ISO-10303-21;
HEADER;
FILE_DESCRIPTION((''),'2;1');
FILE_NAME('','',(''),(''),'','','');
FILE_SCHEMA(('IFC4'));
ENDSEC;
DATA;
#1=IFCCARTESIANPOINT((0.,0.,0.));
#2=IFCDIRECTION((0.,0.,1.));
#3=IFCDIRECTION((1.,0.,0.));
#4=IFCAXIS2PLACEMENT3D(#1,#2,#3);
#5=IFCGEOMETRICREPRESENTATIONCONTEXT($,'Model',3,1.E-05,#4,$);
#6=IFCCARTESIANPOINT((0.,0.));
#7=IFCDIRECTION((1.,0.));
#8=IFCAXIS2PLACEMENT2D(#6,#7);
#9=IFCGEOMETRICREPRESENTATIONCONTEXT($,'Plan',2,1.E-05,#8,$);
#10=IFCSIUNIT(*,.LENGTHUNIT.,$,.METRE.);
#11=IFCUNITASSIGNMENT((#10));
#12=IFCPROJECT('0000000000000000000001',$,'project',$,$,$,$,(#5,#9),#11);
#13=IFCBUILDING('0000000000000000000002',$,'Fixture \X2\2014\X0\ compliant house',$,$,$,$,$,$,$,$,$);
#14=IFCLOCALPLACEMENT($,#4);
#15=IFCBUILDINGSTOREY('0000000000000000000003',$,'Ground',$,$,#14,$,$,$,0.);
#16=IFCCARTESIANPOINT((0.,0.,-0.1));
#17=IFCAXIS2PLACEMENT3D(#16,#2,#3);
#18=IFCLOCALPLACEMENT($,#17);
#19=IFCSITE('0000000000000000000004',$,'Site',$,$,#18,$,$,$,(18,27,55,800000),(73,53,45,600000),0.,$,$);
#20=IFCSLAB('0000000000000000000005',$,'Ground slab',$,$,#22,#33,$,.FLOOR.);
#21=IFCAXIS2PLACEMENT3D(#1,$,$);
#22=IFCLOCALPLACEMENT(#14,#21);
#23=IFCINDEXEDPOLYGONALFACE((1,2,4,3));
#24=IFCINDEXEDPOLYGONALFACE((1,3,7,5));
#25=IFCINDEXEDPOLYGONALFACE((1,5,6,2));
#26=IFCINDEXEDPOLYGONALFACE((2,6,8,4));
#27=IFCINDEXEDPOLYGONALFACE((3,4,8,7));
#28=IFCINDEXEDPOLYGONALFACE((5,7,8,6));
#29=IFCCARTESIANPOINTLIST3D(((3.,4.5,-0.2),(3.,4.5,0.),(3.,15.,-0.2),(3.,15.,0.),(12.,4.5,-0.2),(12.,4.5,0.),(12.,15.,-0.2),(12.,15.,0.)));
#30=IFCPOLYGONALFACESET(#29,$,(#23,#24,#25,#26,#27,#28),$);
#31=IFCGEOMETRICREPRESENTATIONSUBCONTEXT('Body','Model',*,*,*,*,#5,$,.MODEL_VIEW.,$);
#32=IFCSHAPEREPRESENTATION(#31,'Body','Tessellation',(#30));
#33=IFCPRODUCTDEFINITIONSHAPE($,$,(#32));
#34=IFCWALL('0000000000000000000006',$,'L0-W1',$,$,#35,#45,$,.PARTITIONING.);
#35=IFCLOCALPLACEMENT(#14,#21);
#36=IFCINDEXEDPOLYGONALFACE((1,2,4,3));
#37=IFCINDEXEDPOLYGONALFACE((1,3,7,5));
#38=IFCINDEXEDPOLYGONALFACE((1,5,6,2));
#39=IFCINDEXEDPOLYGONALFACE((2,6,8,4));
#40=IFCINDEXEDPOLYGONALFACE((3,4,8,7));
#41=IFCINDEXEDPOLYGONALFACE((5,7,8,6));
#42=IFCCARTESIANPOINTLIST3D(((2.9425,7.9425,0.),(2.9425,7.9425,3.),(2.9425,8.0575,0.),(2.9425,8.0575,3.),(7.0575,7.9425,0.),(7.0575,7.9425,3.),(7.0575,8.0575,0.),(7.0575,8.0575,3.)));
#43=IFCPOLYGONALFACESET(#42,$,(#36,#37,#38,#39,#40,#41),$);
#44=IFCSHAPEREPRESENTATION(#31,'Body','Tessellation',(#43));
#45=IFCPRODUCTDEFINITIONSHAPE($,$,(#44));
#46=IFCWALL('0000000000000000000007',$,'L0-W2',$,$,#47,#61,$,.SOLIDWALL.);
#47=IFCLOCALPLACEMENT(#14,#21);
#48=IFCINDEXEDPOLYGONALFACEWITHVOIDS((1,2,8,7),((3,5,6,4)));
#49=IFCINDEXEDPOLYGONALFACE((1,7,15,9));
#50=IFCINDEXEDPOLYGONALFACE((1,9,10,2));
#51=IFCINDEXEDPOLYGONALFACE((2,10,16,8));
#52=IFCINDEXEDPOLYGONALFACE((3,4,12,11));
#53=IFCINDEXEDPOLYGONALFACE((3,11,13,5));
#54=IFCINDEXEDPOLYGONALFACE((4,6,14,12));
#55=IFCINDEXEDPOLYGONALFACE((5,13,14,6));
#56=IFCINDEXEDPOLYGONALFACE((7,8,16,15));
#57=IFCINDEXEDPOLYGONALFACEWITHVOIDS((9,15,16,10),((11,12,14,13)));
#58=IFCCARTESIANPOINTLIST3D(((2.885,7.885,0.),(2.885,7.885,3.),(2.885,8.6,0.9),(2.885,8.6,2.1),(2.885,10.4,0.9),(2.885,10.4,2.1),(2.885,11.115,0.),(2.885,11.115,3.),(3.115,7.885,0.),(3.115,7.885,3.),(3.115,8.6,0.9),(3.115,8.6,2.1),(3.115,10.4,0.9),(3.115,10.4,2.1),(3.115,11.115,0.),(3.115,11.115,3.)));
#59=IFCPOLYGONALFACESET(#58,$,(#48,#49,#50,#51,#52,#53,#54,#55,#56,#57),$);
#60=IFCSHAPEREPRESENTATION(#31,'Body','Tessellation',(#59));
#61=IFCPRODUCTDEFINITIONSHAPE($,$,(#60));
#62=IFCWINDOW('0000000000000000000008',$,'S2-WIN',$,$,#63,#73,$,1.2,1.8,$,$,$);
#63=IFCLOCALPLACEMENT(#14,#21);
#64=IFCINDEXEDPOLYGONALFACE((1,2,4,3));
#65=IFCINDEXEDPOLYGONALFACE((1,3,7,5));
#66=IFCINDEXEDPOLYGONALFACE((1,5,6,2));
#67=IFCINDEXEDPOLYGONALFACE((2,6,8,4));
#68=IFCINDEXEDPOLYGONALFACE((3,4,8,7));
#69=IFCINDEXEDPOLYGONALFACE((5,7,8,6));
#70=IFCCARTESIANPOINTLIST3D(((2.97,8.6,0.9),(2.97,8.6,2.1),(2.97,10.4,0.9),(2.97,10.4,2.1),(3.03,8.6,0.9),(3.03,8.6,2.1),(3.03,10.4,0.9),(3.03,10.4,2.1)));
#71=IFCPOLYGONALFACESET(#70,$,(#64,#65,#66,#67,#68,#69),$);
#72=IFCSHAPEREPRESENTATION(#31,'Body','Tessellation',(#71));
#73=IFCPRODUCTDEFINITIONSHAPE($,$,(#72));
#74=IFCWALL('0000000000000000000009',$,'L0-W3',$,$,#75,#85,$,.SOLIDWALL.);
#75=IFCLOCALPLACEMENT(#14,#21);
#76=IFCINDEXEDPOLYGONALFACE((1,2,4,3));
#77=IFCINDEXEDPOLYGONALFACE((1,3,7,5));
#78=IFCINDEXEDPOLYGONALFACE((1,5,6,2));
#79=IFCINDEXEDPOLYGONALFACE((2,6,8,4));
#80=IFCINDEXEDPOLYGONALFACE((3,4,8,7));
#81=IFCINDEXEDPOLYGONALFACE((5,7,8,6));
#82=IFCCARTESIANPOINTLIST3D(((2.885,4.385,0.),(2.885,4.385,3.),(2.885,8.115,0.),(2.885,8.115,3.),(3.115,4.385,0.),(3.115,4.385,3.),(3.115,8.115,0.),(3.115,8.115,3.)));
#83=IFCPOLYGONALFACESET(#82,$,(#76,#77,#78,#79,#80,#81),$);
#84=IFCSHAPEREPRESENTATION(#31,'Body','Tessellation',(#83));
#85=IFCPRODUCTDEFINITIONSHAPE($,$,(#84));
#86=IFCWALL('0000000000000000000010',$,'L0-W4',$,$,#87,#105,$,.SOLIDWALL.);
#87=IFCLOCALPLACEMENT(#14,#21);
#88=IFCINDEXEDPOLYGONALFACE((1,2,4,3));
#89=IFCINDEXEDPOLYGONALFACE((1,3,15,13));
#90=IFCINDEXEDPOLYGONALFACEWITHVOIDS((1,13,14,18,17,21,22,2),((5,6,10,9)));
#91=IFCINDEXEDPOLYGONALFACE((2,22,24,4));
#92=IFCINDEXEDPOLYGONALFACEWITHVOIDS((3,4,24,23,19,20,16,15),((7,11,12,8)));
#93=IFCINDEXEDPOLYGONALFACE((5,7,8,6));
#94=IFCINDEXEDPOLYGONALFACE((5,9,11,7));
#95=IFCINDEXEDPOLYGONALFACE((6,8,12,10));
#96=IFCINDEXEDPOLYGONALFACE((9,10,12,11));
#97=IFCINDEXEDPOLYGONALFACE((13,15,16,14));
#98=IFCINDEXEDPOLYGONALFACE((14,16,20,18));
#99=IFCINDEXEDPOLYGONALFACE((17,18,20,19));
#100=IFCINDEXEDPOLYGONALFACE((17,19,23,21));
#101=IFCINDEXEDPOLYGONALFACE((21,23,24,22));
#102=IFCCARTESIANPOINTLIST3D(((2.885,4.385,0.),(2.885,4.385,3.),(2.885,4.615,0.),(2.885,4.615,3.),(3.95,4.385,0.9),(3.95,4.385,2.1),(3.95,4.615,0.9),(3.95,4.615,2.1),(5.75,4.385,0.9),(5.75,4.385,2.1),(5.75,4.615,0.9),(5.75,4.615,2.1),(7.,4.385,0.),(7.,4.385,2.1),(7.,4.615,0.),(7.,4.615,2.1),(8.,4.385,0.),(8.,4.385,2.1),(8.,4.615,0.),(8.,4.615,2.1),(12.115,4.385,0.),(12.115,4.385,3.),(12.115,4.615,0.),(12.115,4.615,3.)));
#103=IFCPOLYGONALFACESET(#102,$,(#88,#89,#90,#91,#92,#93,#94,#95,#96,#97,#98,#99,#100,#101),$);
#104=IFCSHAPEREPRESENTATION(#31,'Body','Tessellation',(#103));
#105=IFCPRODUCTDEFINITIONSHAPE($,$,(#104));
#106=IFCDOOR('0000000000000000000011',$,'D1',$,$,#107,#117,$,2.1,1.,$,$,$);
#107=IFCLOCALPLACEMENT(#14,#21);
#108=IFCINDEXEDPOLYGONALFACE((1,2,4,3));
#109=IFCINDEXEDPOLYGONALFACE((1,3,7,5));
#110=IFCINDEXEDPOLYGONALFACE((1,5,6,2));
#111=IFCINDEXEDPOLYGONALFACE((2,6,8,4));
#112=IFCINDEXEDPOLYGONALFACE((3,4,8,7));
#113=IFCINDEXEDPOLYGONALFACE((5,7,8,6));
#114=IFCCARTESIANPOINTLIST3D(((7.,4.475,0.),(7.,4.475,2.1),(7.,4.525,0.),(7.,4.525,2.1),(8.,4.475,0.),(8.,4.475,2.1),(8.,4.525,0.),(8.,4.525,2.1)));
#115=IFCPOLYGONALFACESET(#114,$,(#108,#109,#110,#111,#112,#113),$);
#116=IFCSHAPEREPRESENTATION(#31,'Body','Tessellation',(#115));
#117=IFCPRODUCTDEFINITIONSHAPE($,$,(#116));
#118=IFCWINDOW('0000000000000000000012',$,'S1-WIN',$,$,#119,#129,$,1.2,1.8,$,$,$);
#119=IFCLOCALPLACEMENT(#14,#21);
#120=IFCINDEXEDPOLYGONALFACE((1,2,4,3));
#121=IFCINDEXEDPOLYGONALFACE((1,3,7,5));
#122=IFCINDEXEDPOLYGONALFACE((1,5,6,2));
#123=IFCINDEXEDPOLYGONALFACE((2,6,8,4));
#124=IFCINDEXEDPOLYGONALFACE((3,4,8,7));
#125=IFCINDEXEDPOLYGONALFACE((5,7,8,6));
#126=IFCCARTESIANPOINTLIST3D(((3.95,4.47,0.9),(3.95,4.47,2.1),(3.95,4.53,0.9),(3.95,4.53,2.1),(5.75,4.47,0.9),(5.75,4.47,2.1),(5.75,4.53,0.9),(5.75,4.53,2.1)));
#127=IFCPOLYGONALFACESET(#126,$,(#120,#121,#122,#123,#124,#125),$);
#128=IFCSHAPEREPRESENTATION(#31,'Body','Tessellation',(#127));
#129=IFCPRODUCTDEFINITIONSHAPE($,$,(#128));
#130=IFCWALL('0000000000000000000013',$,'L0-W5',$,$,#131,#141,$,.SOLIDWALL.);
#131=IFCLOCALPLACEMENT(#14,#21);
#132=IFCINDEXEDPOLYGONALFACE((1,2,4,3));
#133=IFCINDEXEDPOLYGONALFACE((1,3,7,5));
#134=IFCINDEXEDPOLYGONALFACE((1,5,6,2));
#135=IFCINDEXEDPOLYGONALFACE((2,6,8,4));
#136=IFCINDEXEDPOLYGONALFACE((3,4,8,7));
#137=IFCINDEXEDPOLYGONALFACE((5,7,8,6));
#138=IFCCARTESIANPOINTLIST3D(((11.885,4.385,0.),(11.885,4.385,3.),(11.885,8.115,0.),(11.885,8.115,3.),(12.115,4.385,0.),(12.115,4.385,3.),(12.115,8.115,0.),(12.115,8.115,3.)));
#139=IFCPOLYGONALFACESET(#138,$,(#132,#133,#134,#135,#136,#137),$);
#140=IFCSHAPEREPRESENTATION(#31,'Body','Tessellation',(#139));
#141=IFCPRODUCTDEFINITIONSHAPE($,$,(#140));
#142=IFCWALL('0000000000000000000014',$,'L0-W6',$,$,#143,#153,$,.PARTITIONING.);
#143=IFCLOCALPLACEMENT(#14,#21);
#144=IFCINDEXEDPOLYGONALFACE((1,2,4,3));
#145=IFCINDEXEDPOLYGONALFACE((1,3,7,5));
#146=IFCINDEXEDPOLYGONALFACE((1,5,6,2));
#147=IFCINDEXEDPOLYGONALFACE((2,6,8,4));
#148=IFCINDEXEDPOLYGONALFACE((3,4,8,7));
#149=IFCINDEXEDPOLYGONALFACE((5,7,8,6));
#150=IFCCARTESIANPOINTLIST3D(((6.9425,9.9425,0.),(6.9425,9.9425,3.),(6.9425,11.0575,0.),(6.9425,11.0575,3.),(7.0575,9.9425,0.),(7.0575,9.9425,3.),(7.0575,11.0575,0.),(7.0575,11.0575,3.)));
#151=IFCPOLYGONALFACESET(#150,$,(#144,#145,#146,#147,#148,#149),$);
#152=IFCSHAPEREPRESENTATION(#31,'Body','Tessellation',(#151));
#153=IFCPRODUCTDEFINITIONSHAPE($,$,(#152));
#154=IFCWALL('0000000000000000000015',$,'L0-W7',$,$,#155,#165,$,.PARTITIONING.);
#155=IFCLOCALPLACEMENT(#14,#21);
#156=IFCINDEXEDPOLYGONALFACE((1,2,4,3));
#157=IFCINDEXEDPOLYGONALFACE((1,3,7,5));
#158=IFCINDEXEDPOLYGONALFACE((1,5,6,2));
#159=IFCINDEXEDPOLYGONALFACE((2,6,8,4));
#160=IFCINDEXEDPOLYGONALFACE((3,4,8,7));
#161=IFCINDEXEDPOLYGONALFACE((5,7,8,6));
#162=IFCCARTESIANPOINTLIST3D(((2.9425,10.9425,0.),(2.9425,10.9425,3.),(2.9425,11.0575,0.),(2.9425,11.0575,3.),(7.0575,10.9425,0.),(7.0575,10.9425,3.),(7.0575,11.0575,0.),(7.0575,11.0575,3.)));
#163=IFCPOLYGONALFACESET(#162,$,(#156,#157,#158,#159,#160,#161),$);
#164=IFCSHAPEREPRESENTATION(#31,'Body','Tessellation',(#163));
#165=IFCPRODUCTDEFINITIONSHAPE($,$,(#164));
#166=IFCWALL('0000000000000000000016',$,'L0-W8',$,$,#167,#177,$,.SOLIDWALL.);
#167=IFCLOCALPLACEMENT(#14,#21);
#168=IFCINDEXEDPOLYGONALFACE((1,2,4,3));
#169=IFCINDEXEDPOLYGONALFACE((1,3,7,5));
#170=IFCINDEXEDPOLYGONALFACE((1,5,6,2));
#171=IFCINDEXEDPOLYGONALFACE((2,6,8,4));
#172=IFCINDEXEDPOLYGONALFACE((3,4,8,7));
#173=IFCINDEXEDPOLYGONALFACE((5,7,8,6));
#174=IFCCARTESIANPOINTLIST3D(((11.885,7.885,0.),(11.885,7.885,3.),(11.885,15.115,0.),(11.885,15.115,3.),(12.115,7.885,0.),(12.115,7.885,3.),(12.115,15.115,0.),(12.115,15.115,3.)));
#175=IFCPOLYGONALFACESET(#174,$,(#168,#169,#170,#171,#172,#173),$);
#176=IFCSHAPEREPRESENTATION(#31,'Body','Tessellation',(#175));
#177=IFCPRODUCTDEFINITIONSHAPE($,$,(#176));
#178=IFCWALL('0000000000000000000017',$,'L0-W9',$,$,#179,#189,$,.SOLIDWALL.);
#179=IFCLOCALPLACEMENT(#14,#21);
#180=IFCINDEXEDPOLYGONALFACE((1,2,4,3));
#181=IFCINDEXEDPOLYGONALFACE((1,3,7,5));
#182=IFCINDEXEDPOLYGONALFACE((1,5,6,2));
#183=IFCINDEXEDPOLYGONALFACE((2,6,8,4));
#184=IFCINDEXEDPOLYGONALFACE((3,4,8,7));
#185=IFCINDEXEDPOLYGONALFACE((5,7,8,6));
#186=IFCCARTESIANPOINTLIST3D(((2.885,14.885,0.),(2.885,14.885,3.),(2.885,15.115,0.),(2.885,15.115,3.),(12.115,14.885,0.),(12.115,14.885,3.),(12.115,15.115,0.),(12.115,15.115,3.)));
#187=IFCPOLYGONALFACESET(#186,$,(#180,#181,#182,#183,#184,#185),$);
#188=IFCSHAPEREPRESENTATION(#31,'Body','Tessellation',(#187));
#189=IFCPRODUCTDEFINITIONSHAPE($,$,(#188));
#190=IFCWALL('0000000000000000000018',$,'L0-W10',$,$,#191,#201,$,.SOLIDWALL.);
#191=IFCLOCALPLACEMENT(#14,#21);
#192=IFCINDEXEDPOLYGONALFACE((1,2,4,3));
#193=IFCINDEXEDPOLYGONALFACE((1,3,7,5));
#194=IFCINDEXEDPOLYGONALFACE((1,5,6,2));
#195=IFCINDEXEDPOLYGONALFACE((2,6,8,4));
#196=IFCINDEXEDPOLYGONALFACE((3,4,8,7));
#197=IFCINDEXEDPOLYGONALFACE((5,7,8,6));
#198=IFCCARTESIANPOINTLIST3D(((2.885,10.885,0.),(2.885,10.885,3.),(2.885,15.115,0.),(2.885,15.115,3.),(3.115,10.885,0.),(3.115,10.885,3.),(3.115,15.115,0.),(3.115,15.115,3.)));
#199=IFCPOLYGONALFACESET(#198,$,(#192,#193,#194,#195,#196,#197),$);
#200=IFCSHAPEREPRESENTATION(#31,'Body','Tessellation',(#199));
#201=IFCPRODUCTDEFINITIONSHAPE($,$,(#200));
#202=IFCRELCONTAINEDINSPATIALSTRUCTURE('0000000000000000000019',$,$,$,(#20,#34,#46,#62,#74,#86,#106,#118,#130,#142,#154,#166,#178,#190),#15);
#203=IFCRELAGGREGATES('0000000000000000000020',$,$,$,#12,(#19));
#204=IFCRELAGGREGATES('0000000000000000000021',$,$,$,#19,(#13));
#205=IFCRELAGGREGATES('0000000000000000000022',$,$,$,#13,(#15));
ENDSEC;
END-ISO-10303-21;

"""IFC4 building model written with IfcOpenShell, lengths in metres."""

from ifc_helpers import new_model, si_unit, frame, origin_with_axes, origin_2d_with_axis, place, context, subcontext, project, spatial, line, indexed_curve, outline, extrude, element, fill, save


model = new_model("IFC4")

# Units and contexts
model_context = context("Model", 3, precision=1e-05, world=origin_with_axes())
plan_context = context("Plan", 2, precision=1e-05, world=origin_2d_with_axis())
body_context = subcontext(model_context, "Body", "Model", "MODEL_VIEW")
ifc_project = project(units=[si_unit("LENGTHUNIT", "METRE")], contexts=[model_context, plan_context])

# Site, building, storey
site_placement = place(None, frame((0.0, 0.0, -0.1), z_axis=(0.0, 0.0, 1.0), x_axis=(1.0, 0.0, 0.0)))
site = spatial("IfcSite", under=ifc_project, at=site_placement, Name="Site", RefLatitude=(18, 27, 55, 800000), RefLongitude=(73, 53, 45, 600000), RefElevation=0.0)
building = spatial("IfcBuilding", under=site, Name="Fixture — compliant house")
storey_placement = place(None, origin_with_axes())
storey = spatial("IfcBuildingStorey", under=building, at=storey_placement, Name="Ground", Elevation=0.0)

# Slab
slab_placement = place(storey_placement, frame((0.0, 0.0, -0.2), z_axis=(0.0, 0.0, 1.0), x_axis=(1.0, 0.0, 0.0)))
element("IfcSlab", 1, at=slab_placement, inside=storey, Name="Ground slab", PredefinedType="FLOOR", context=body_context, shape_type="SweptSolid", body=[
    extrude(outline(indexed_curve([(3.0, 4.5), (12.0, 4.5), (12.0, 15.0), (3.0, 15.0)], segments=[line(1, 2, 3, 4, 1)])), origin_with_axes(), (0.0, 0.0, 1.0), 0.2),
])

# Wall
wall_1_placement = place(storey_placement, origin_with_axes())
element("IfcWall", 2, at=wall_1_placement, inside=storey, Name="L0-W1", PredefinedType="PARTITIONING", context=body_context, shape_type="SweptSolid", body=[
    extrude(outline(indexed_curve([(7.0575, 7.9425), (2.9425, 7.9425), (2.9425, 8.0575), (7.0575, 8.0575)], segments=[line(1, 2, 3, 4, 1)])), origin_with_axes(), (0.0, 0.0, 1.0), 3.0),
])

# Wall, opening, window
wall_2_placement = place(storey_placement, origin_with_axes())
wall_2 = element("IfcWall", 3, at=wall_2_placement, inside=storey, Name="L0-W2", PredefinedType="SOLIDWALL", context=body_context, shape_type="SweptSolid", body=[
    extrude(outline(indexed_curve([(3.115, 11.115), (3.115, 7.885), (2.885, 7.885), (2.885, 11.115)], segments=[line(1, 2, 3, 4, 1)])), origin_with_axes(), (0.0, 0.0, 1.0), 3.0),
])
opening_1_placement = place(wall_2_placement, origin_with_axes())
opening_1 = element("IfcOpeningElement", 4, at=opening_1_placement, cuts=wall_2, context=body_context, shape_type="SweptSolid", body=[
    extrude(outline(indexed_curve([(3.165, 10.4), (3.165, 8.6), (2.835, 8.6), (2.835, 10.4)], segments=[line(1, 2, 3, 4, 1)])), frame((0.0, 0.0, 0.9), z_axis=(0.0, 0.0, 1.0), x_axis=(1.0, 0.0, 0.0)), (0.0, 0.0, 1.0), 1.2),
])
window_1_placement = place(storey_placement, origin_with_axes())
window_1 = element("IfcWindow", 5, at=window_1_placement, inside=storey, Name="S2-WIN", OverallHeight=1.2, OverallWidth=1.8, context=body_context, shape_type="SweptSolid", body=[
    extrude(outline(indexed_curve([(3.03, 10.4), (3.03, 8.6), (2.97, 8.6), (2.97, 10.4)], segments=[line(1, 2, 3, 4, 1)])), frame((0.0, 0.0, 0.9), z_axis=(0.0, 0.0, 1.0), x_axis=(1.0, 0.0, 0.0)), (0.0, 0.0, 1.0), 1.2),
])
fill(opening_1, window_1)

# Wall
wall_3_placement = place(storey_placement, origin_with_axes())
element("IfcWall", 6, at=wall_3_placement, inside=storey, Name="L0-W3", PredefinedType="SOLIDWALL", context=body_context, shape_type="SweptSolid", body=[
    extrude(outline(indexed_curve([(3.115, 8.115), (3.115, 4.385), (2.885, 4.385), (2.885, 8.115)], segments=[line(1, 2, 3, 4, 1)])), origin_with_axes(), (0.0, 0.0, 1.0), 3.0),
])

# Wall, openings, door, window
wall_4_placement = place(storey_placement, origin_with_axes())
wall_4 = element("IfcWall", 7, at=wall_4_placement, inside=storey, Name="L0-W4", PredefinedType="SOLIDWALL", context=body_context, shape_type="SweptSolid", body=[
    extrude(outline(indexed_curve([(2.885, 4.615), (12.115, 4.615), (12.115, 4.385), (2.885, 4.385)], segments=[line(1, 2, 3, 4, 1)])), origin_with_axes(), (0.0, 0.0, 1.0), 3.0),
])
opening_2_placement = place(wall_4_placement, origin_with_axes())
opening_2 = element("IfcOpeningElement", 8, at=opening_2_placement, cuts=wall_4, context=body_context, shape_type="SweptSolid", body=[
    extrude(outline(indexed_curve([(7.0, 4.665), (8.0, 4.665), (8.0, 4.335), (7.0, 4.335)], segments=[line(1, 2, 3, 4, 1)])), origin_with_axes(), (0.0, 0.0, 1.0), 2.1),
])
opening_3_placement = place(wall_4_placement, origin_with_axes())
opening_3 = element("IfcOpeningElement", 9, at=opening_3_placement, cuts=wall_4, context=body_context, shape_type="SweptSolid", body=[
    extrude(outline(indexed_curve([(3.95, 4.665), (5.75, 4.665), (5.75, 4.335), (3.95, 4.335)], segments=[line(1, 2, 3, 4, 1)])), frame((0.0, 0.0, 0.9), z_axis=(0.0, 0.0, 1.0), x_axis=(1.0, 0.0, 0.0)), (0.0, 0.0, 1.0), 1.2),
])
door_1_placement = place(storey_placement, origin_with_axes())
door_1 = element("IfcDoor", 10, at=door_1_placement, inside=storey, Name="D1", OverallHeight=2.1, OverallWidth=1.0, context=body_context, shape_type="SweptSolid", body=[
    extrude(outline(indexed_curve([(7.0, 4.525), (8.0, 4.525), (8.0, 4.475), (7.0, 4.475)], segments=[line(1, 2, 3, 4, 1)])), origin_with_axes(), (0.0, 0.0, 1.0), 2.1),
])
fill(opening_2, door_1)
window_2_placement = place(storey_placement, origin_with_axes())
window_2 = element("IfcWindow", 11, at=window_2_placement, inside=storey, Name="S1-WIN", OverallHeight=1.2, OverallWidth=1.8, context=body_context, shape_type="SweptSolid", body=[
    extrude(outline(indexed_curve([(3.95, 4.53), (5.75, 4.53), (5.75, 4.47), (3.95, 4.47)], segments=[line(1, 2, 3, 4, 1)])), frame((0.0, 0.0, 0.9), z_axis=(0.0, 0.0, 1.0), x_axis=(1.0, 0.0, 0.0)), (0.0, 0.0, 1.0), 1.2),
])
fill(opening_3, window_2)

# Walls
wall_5_placement = place(storey_placement, origin_with_axes())
element("IfcWall", 12, at=wall_5_placement, inside=storey, Name="L0-W5", PredefinedType="SOLIDWALL", context=body_context, shape_type="SweptSolid", body=[
    extrude(outline(indexed_curve([(11.885, 4.385), (11.885, 8.115), (12.115, 8.115), (12.115, 4.385)], segments=[line(1, 2, 3, 4, 1)])), origin_with_axes(), (0.0, 0.0, 1.0), 3.0),
])
wall_6_placement = place(storey_placement, origin_with_axes())
element("IfcWall", 13, at=wall_6_placement, inside=storey, Name="L0-W6", PredefinedType="PARTITIONING", context=body_context, shape_type="SweptSolid", body=[
    extrude(outline(indexed_curve([(6.9425, 9.9425), (6.9425, 11.0575), (7.0575, 11.0575), (7.0575, 9.9425)], segments=[line(1, 2, 3, 4, 1)])), origin_with_axes(), (0.0, 0.0, 1.0), 3.0),
])
wall_7_placement = place(storey_placement, origin_with_axes())
element("IfcWall", 14, at=wall_7_placement, inside=storey, Name="L0-W7", PredefinedType="PARTITIONING", context=body_context, shape_type="SweptSolid", body=[
    extrude(outline(indexed_curve([(7.0575, 10.9425), (2.9425, 10.9425), (2.9425, 11.0575), (7.0575, 11.0575)], segments=[line(1, 2, 3, 4, 1)])), origin_with_axes(), (0.0, 0.0, 1.0), 3.0),
])
wall_8_placement = place(storey_placement, origin_with_axes())
element("IfcWall", 15, at=wall_8_placement, inside=storey, Name="L0-W8", PredefinedType="SOLIDWALL", context=body_context, shape_type="SweptSolid", body=[
    extrude(outline(indexed_curve([(11.885, 7.885), (11.885, 15.115), (12.115, 15.115), (12.115, 7.885)], segments=[line(1, 2, 3, 4, 1)])), origin_with_axes(), (0.0, 0.0, 1.0), 3.0),
])
wall_9_placement = place(storey_placement, origin_with_axes())
element("IfcWall", 16, at=wall_9_placement, inside=storey, Name="L0-W9", PredefinedType="SOLIDWALL", context=body_context, shape_type="SweptSolid", body=[
    extrude(outline(indexed_curve([(12.115, 14.885), (2.885, 14.885), (2.885, 15.115), (12.115, 15.115)], segments=[line(1, 2, 3, 4, 1)])), origin_with_axes(), (0.0, 0.0, 1.0), 3.0),
])
wall_10_placement = place(storey_placement, origin_with_axes())
element("IfcWall", 17, at=wall_10_placement, inside=storey, Name="L0-W10", PredefinedType="SOLIDWALL", context=body_context, shape_type="SweptSolid", body=[
    extrude(outline(indexed_curve([(3.115, 15.115), (3.115, 10.885), (2.885, 10.885), (2.885, 15.115)], segments=[line(1, 2, 3, 4, 1)])), origin_with_axes(), (0.0, 0.0, 1.0), 3.0),
])

save(model, "model.ifc")
